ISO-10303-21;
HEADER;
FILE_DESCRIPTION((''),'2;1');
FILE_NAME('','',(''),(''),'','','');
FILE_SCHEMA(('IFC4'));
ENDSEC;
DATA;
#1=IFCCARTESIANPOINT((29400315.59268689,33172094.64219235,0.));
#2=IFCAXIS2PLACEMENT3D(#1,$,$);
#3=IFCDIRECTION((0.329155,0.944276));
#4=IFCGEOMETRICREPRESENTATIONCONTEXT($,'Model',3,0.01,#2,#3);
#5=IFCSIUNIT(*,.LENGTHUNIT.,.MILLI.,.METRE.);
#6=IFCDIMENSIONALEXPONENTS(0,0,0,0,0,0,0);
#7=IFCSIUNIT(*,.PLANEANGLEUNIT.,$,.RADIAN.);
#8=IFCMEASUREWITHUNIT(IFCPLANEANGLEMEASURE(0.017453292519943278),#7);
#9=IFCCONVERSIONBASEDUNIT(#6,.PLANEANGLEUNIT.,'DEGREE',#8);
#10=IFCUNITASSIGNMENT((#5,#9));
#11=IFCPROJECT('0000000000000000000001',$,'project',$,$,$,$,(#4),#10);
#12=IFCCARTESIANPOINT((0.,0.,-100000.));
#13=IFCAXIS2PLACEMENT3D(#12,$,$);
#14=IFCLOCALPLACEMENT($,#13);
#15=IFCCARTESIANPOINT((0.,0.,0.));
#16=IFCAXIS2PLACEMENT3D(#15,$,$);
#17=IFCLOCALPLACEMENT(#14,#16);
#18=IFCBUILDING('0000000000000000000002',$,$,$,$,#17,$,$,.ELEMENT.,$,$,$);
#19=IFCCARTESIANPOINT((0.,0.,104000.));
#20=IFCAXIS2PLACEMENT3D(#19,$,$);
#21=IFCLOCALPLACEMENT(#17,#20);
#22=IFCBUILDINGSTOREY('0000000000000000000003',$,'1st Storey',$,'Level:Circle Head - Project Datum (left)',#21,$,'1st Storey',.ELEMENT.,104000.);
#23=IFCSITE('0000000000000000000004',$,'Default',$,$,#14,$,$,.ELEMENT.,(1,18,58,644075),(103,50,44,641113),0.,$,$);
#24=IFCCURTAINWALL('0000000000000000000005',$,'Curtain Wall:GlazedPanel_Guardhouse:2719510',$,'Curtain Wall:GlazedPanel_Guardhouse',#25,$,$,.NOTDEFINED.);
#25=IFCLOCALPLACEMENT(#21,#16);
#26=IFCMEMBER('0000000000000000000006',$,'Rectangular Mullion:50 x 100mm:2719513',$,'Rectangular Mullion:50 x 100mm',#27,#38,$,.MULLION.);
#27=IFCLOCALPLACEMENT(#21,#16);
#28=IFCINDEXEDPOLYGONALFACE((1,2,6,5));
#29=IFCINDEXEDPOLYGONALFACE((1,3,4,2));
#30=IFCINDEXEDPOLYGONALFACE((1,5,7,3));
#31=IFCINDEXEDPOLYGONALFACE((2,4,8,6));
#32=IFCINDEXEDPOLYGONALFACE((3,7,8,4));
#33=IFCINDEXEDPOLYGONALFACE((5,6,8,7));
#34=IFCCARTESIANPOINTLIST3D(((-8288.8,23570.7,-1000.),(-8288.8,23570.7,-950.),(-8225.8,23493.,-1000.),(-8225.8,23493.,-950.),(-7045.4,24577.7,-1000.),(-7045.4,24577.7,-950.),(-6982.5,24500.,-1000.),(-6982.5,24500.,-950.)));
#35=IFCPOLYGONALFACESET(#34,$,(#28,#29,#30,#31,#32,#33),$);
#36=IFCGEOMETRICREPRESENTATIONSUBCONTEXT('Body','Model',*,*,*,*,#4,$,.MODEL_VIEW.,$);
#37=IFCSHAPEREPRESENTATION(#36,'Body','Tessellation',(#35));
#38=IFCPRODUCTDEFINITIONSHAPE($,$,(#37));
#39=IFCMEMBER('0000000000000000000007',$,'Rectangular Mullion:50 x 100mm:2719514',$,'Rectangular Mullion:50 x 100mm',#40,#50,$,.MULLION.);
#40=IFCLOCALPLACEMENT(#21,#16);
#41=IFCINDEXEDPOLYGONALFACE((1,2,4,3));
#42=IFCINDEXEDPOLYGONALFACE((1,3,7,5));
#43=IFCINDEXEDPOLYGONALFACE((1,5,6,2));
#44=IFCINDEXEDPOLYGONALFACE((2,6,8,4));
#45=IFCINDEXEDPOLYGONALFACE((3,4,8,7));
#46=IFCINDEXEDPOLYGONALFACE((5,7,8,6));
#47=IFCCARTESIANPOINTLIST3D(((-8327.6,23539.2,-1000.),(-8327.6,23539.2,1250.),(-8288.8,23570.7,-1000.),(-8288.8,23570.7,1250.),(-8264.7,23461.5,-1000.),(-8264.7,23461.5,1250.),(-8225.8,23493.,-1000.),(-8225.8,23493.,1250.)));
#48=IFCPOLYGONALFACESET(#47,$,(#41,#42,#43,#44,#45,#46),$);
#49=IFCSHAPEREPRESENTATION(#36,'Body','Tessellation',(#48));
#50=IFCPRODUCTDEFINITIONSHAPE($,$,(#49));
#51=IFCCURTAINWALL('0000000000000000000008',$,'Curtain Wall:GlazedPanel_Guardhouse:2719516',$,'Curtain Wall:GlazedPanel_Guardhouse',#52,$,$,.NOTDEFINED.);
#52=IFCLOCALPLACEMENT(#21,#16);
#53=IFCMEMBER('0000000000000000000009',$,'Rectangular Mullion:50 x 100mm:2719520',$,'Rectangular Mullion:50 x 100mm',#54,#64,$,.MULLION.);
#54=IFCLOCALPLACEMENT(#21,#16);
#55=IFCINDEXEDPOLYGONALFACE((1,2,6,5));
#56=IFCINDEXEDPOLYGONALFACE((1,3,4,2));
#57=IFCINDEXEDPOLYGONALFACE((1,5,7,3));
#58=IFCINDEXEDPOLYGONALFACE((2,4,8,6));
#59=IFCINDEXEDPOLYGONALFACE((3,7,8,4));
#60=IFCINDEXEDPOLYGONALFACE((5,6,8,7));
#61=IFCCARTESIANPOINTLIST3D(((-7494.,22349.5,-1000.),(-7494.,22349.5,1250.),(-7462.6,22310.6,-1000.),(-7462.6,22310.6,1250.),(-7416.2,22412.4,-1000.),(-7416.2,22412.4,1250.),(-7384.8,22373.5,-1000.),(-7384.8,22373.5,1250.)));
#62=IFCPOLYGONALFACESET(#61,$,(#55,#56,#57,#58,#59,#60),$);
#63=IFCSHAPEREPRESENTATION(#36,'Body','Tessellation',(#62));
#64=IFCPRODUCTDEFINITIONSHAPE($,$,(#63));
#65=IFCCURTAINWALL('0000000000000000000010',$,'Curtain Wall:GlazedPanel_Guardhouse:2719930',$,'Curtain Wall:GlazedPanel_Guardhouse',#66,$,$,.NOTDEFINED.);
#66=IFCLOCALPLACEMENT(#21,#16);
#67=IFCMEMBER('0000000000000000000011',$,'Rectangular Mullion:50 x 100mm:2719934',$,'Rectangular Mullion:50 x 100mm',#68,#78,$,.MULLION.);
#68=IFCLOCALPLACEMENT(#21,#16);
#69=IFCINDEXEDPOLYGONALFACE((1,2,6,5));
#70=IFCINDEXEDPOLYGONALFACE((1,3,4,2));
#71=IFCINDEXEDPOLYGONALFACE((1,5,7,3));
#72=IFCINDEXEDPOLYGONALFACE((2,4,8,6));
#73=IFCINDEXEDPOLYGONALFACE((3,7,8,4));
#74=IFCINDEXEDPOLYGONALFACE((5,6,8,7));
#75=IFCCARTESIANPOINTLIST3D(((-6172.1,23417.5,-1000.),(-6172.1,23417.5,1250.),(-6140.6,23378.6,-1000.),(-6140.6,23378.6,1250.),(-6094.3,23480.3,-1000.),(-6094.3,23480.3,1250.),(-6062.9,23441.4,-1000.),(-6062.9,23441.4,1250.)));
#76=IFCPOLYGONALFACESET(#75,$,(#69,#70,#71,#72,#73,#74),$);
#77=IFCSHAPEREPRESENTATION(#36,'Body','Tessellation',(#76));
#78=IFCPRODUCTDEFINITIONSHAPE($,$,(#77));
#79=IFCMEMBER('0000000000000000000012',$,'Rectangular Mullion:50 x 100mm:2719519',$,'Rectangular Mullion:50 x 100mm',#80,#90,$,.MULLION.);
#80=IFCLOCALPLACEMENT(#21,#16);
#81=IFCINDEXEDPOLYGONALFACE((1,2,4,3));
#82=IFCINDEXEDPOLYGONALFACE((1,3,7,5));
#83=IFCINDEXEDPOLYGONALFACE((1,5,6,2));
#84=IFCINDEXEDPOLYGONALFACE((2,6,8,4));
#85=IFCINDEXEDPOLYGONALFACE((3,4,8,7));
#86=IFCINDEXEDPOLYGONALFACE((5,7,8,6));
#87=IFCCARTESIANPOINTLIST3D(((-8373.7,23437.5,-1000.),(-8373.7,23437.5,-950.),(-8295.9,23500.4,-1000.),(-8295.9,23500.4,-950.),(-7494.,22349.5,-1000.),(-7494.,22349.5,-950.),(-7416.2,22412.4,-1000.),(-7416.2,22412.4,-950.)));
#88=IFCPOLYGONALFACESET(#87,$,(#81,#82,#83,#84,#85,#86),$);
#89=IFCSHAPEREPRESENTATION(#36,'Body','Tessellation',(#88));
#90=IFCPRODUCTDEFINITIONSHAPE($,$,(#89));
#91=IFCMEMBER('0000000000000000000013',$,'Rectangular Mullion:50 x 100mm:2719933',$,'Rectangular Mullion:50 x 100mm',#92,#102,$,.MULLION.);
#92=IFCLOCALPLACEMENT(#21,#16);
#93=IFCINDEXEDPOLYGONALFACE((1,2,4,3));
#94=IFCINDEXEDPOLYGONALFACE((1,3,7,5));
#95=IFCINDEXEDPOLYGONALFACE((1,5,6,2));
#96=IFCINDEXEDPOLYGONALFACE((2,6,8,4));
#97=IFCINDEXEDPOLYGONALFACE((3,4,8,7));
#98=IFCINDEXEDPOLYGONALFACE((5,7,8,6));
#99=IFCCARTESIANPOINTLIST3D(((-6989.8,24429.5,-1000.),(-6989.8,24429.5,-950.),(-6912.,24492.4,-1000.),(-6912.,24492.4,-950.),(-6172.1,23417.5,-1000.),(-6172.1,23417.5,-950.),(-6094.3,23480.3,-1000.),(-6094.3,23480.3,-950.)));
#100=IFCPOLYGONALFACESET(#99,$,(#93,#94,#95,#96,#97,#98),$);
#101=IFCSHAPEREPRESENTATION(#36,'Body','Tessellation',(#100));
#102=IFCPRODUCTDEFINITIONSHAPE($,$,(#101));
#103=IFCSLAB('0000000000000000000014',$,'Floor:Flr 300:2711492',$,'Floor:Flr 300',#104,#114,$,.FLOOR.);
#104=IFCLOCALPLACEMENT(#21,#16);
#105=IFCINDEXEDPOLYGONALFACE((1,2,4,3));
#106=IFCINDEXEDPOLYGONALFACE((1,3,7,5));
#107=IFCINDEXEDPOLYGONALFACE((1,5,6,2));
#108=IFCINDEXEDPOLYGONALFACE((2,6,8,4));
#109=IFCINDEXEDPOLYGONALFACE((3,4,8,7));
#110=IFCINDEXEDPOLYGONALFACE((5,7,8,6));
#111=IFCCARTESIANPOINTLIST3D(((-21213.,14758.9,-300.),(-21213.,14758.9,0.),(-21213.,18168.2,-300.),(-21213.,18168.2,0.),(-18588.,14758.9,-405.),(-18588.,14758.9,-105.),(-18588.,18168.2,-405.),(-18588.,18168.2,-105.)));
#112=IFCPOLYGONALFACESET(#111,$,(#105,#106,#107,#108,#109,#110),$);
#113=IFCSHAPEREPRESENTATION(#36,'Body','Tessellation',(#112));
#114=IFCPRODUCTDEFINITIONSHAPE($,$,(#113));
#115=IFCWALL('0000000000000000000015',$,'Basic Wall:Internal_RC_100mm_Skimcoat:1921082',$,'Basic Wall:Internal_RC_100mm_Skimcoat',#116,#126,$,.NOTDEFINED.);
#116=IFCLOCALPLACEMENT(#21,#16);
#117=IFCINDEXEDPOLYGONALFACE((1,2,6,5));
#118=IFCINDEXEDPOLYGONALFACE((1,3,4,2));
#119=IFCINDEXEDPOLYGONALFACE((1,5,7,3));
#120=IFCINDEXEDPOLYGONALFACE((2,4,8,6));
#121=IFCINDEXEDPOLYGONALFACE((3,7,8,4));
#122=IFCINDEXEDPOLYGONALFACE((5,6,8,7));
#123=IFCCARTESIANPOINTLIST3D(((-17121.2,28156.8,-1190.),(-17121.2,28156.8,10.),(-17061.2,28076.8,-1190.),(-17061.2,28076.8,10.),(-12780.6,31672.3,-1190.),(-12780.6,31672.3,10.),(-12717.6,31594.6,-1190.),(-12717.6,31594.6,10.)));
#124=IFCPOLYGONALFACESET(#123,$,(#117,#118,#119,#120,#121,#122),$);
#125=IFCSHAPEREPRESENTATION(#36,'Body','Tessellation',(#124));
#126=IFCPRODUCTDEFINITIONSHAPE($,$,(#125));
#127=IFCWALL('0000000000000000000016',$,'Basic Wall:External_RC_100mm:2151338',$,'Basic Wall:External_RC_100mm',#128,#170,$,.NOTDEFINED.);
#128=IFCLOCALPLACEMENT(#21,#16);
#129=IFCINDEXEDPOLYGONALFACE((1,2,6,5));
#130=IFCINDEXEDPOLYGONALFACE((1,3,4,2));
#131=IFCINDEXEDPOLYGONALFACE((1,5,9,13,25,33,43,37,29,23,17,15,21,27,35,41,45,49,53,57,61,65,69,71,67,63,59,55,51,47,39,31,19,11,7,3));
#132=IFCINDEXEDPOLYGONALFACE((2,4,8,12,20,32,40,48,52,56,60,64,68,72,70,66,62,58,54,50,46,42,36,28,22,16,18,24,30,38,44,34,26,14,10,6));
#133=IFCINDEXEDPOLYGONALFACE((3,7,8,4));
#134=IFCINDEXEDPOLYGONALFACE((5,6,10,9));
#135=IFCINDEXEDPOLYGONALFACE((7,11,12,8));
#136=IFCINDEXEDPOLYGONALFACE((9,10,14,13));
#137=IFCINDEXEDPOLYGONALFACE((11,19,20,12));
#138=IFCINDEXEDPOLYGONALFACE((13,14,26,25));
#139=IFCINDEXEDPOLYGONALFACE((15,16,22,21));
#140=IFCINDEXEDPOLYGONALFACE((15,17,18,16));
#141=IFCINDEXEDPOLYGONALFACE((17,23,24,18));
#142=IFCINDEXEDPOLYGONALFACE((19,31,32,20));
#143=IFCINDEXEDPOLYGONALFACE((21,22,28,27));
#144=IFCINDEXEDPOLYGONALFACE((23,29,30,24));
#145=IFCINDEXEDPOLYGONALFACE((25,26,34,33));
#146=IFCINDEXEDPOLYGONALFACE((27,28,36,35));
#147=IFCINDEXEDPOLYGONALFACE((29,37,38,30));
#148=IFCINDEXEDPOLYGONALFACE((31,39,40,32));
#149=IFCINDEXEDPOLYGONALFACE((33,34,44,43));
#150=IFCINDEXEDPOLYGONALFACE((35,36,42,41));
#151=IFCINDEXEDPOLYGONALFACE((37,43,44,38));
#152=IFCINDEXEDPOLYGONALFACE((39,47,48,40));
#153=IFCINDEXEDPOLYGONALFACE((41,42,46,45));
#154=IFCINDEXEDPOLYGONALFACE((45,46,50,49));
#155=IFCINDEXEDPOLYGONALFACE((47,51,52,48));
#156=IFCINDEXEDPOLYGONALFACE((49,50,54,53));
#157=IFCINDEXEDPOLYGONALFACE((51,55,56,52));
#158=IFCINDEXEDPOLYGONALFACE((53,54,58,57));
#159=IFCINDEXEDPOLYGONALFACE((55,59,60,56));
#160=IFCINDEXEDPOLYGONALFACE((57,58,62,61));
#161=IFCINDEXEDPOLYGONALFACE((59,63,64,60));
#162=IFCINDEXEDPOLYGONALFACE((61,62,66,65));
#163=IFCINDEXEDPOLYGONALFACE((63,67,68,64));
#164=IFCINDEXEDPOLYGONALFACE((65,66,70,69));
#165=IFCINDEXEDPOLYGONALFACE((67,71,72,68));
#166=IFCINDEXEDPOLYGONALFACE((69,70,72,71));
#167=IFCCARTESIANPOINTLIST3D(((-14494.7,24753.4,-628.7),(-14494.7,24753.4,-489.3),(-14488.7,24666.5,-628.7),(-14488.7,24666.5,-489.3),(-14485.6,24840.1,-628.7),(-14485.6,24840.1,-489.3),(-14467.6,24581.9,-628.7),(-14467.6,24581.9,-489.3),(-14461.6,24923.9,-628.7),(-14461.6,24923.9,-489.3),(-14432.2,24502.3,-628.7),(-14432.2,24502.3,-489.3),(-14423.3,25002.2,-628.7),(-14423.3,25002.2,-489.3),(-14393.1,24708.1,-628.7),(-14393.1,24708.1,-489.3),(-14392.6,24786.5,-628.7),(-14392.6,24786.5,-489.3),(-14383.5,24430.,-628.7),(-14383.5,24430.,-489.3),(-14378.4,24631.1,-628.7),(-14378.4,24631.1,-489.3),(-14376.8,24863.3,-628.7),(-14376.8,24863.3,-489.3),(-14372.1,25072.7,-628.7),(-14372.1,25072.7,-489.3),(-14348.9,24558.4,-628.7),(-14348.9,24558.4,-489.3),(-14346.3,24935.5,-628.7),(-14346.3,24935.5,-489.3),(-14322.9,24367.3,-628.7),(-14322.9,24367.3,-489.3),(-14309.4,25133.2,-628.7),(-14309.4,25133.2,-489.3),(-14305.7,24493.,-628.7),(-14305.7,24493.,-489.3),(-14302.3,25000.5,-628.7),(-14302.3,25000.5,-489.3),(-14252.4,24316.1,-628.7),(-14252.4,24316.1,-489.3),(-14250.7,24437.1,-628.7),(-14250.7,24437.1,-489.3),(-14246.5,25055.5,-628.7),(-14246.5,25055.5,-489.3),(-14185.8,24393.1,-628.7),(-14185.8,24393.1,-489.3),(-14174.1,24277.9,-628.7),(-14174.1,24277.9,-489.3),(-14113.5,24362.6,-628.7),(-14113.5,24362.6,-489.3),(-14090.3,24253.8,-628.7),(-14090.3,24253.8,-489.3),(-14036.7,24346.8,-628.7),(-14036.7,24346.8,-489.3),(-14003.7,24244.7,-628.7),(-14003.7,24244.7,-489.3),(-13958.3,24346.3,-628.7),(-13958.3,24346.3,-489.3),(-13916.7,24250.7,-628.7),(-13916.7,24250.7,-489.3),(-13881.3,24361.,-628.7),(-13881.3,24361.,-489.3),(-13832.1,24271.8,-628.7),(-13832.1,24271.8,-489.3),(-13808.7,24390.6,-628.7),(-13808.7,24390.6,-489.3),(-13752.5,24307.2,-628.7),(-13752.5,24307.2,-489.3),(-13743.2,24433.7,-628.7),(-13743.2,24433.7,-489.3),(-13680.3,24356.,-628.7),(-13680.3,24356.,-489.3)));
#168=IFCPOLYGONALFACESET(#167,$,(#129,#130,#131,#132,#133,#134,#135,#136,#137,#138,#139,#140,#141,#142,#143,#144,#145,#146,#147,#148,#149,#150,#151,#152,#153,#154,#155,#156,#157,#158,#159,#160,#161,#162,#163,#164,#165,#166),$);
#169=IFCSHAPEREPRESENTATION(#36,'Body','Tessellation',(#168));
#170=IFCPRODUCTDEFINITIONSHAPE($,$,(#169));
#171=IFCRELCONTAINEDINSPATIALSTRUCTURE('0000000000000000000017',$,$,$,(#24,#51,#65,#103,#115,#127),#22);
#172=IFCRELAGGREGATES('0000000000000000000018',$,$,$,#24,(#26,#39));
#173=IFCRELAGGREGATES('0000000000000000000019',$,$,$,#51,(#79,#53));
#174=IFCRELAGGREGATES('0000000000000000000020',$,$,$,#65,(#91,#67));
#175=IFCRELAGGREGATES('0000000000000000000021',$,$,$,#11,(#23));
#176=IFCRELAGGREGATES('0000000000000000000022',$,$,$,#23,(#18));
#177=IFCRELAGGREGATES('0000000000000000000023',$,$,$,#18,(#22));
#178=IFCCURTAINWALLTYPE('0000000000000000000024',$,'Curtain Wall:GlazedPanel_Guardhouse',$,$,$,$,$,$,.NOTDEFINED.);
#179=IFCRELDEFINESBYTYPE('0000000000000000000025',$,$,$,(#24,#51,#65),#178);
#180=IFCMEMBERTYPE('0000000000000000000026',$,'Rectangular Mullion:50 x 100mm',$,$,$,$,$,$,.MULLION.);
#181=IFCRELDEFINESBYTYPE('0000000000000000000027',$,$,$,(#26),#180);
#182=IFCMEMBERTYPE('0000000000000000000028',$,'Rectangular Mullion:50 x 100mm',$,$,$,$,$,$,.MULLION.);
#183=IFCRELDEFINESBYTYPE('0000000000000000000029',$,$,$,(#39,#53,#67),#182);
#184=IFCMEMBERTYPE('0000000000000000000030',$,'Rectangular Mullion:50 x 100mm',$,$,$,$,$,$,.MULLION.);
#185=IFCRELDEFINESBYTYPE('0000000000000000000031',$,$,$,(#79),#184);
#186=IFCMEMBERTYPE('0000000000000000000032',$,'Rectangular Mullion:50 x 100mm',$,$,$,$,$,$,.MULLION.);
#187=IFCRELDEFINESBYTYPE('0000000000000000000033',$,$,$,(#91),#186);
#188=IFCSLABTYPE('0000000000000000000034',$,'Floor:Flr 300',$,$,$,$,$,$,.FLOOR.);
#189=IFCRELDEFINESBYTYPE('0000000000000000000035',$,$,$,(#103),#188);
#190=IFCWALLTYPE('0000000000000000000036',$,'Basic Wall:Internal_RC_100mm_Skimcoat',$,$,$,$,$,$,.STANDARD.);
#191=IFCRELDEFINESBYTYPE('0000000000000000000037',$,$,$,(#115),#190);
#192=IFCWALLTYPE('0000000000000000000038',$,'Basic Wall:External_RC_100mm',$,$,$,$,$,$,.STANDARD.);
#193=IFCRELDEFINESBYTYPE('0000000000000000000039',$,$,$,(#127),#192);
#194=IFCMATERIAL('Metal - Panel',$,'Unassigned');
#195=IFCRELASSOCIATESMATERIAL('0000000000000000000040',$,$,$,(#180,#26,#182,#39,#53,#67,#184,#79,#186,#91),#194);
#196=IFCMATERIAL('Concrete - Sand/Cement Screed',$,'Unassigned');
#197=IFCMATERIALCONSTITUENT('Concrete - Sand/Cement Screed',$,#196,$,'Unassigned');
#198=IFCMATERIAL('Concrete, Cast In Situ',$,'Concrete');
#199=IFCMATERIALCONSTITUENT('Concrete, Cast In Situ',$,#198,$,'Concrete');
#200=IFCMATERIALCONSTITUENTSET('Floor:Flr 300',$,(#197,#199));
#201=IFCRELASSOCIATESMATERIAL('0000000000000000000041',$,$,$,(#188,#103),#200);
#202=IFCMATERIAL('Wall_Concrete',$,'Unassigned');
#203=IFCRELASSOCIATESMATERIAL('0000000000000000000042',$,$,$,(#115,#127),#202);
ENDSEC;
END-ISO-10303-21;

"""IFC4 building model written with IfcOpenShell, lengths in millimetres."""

from ifc_helpers import new_model, entity, si_unit, converted_unit, direction, frame, frame_2d, origin, place, context, subcontext, project, spatial, line, arc, indexed_curve, rectangle, outline, extrude, source, transform, mapped, material, constituent, constituent_set, type_object, type_shapes, element, aggregate, save


model = new_model("IFC4")

# Units and contexts
model_context = context("Model", 3, precision=0.01, world=frame((29400315.59268689, 33172094.64219235, 0.0)), true_north=direction((0.329155, 0.944276)))
body_context = subcontext(model_context, "Body", "Model", "MODEL_VIEW")
ifc_project = project(units=[si_unit("LENGTHUNIT", "METRE", prefix="MILLI"), converted_unit("PLANEANGLEUNIT", "DEGREE", entity("IfcPlaneAngleMeasure", 0.017453292519943278), si_unit("PLANEANGLEUNIT", "RADIAN"), dimensions=[0, 0, 0, 0, 0, 0, 0])], contexts=[model_context])

# Site, building, storey
site_placement = place(None, frame((0.0, 0.0, -100000.0)))
site = spatial("IfcSite", under=ifc_project, at=site_placement, Name="Default", CompositionType="ELEMENT", RefLatitude=(1, 18, 58, 644075), RefLongitude=(103, 50, 44, 641113), RefElevation=0.0)
building_placement = place(site_placement, origin())
building = spatial("IfcBuilding", under=site, at=building_placement, CompositionType="ELEMENT")
storey_placement = place(building_placement, frame((0.0, 0.0, 104000.0)))
storey = spatial("IfcBuildingStorey", under=building, at=storey_placement, Name="1st Storey", ObjectType="Level:Circle Head - Project Datum (left)", LongName="1st Storey", CompositionType="ELEMENT", Elevation=104000.0)

# Curtain wall, members
curtain_wall_type = type_object("IfcCurtainWallType", Name="Curtain Wall:GlazedPanel_Guardhouse", PredefinedType="NOTDEFINED")
curtain_wall_1_placement = place(storey_placement, frame((0.0, 0.0, -104000.0)))
curtain_wall_1 = element("IfcCurtainWall", 1, at=curtain_wall_1_placement, inside=storey, type_object=curtain_wall_type, Name="Curtain Wall:GlazedPanel_Guardhouse:2719510", ObjectType="Curtain Wall:GlazedPanel_Guardhouse", PredefinedType="NOTDEFINED")
ifc_material_1 = material(Name="Metal - Panel", Category="Unassigned")
member_type_1 = type_object("IfcMemberType", Name="Rectangular Mullion:50 x 100mm", PredefinedType="MULLION", material=ifc_material_1)
shared_shape_1 = source(origin(), body_context, "Body", "SweptSolid", [
    extrude(outline(indexed_curve([(-25.0, -50.0), (25.0, -50.0), (25.0, 50.0), (-25.0, 50.0), (-25.0, -50.0)], self_intersect=False)), frame((-25.0, 0.0, -1600.0), z_axis=(0.0, 0.0, 1.0), x_axis=(-1.0, 0.0, 0.0)), (0.0, 0.0, 1.0), 1600.0),
])
type_shapes(member_type_1, [shared_shape_1])
member_1_placement = place(curtain_wall_1_placement, frame((-7013.9, 24538.8, 103000.0), z_axis=(0.777102, 0.629375, 0.0), x_axis=(0.0, 0.0, -1.0)))
member_1 = element("IfcMember", 2, at=member_1_placement, type_object=member_type_1, material=ifc_material_1, Name="Rectangular Mullion:50 x 100mm:2719513", ObjectType="Rectangular Mullion:50 x 100mm", PredefinedType="MULLION", context=body_context, shape_type="MappedRepresentation", body=[
    mapped(shared_shape_1, transform((0.0, 0.0, 0.0), scale=1.0)),
])
member_type_2 = type_object("IfcMemberType", Name="Rectangular Mullion:50 x 100mm", PredefinedType="MULLION", material=ifc_material_1)
shared_shape_2 = source(origin(), body_context, "Body", "SweptSolid", [
    extrude(outline(indexed_curve([(-25.0, -50.0), (25.0, -50.0), (25.0, 50.0), (-25.0, 50.0), (-25.0, -50.0)], self_intersect=False)), frame((-25.0, 0.0, -2250.0), z_axis=(0.0, 0.0, 1.0), x_axis=(-1.0, 0.0, 0.0)), (0.0, 0.0, 1.0), 2250.0),
])
type_shapes(member_type_2, [shared_shape_2])
member_2_placement = place(curtain_wall_1_placement, frame((-8296.2, 23500.3, 103000.0), z_axis=(0.0, 0.0, -1.0), x_axis=(-0.777102, -0.629375, 0.0)))
member_2 = element("IfcMember", 3, at=member_2_placement, type_object=member_type_2, material=ifc_material_1, Name="Rectangular Mullion:50 x 100mm:2719514", ObjectType="Rectangular Mullion:50 x 100mm", PredefinedType="MULLION", context=body_context, shape_type="MappedRepresentation", body=[
    mapped(shared_shape_2, transform((0.0, 0.0, 0.0), scale=1.0)),
])

# Curtain walls, members
curtain_wall_2_placement = place(storey_placement, frame((0.0, 0.0, -104000.0)))
curtain_wall_2 = element("IfcCurtainWall", 4, at=curtain_wall_2_placement, inside=storey, type_object=curtain_wall_type, Name="Curtain Wall:GlazedPanel_Guardhouse:2719516", ObjectType="Curtain Wall:GlazedPanel_Guardhouse", PredefinedType="NOTDEFINED")
member_3_placement = place(curtain_wall_2_placement, frame((-7423.7, 22342.1, 103000.0), z_axis=(0.0, 0.0, -1.0), x_axis=(0.628737, -0.777618, 0.0)))
member_3 = element("IfcMember", 5, at=member_3_placement, type_object=member_type_2, material=ifc_material_1, Name="Rectangular Mullion:50 x 100mm:2719520", ObjectType="Rectangular Mullion:50 x 100mm", PredefinedType="MULLION", context=body_context, shape_type="MappedRepresentation", body=[
    mapped(shared_shape_2, transform((0.0, 0.0, 0.0), scale=1.0)),
])
curtain_wall_3_placement = place(storey_placement, frame((0.0, 0.0, -104000.0)))
curtain_wall_3 = element("IfcCurtainWall", 6, at=curtain_wall_3_placement, inside=storey, type_object=curtain_wall_type, Name="Curtain Wall:GlazedPanel_Guardhouse:2719930", ObjectType="Curtain Wall:GlazedPanel_Guardhouse", PredefinedType="NOTDEFINED")
member_4_placement = place(curtain_wall_3_placement, frame((-6101.8, 23410.0, 103000.0), z_axis=(0.0, 0.0, -1.0), x_axis=(0.628476, -0.777829, 0.0)))
member_4 = element("IfcMember", 7, at=member_4_placement, type_object=member_type_2, material=ifc_material_1, Name="Rectangular Mullion:50 x 100mm:2719934", ObjectType="Rectangular Mullion:50 x 100mm", PredefinedType="MULLION", context=body_context, shape_type="MappedRepresentation", body=[
    mapped(shared_shape_2, transform((0.0, 0.0, 0.0), scale=1.0)),
])

# Members
member_type_3 = type_object("IfcMemberType", Name="Rectangular Mullion:50 x 100mm", PredefinedType="MULLION", material=ifc_material_1)
shared_shape_3 = source(origin(), body_context, "Body", "SweptSolid", [
    extrude(outline(indexed_curve([(-25.0, -50.0), (25.0, -50.0), (25.0, 50.0), (-25.0, 50.0), (-25.0, -50.0)], self_intersect=False)), frame((-25.0, 0.0, -1399.2), z_axis=(0.0, 0.0, 1.0), x_axis=(-1.0, 0.0, 0.0)), (0.0, 0.0, 1.0), 1399.2),
])
type_shapes(member_type_3, [shared_shape_3])
member_5_placement = place(curtain_wall_2_placement, frame((-8334.8, 23469.0, 103000.0), z_axis=(-0.628737, 0.777618, 0.0), x_axis=(0.0, 0.0, -1.0)))
member_5 = element("IfcMember", 8, at=member_5_placement, type_object=member_type_3, material=ifc_material_1, Name="Rectangular Mullion:50 x 100mm:2719519", ObjectType="Rectangular Mullion:50 x 100mm", PredefinedType="MULLION", context=body_context, shape_type="MappedRepresentation", body=[
    mapped(shared_shape_3, transform((0.0, 0.0, 0.0), scale=1.0)),
])
member_type_4 = type_object("IfcMemberType", Name="Rectangular Mullion:50 x 100mm", PredefinedType="MULLION", material=ifc_material_1)
shared_shape_4 = source(origin(), body_context, "Body", "SweptSolid", [
    extrude(outline(indexed_curve([(-25.0, -50.0), (25.0, -50.0), (25.0, 50.0), (-25.0, 50.0), (-25.0, -50.0)], self_intersect=False)), frame((-25.0, 0.0, -1301.2), z_axis=(0.0, 0.0, 1.0), x_axis=(-1.0, 0.0, 0.0)), (0.0, 0.0, 1.0), 1301.2),
])
type_shapes(member_type_4, [shared_shape_4])
member_6_placement = place(curtain_wall_3_placement, frame((-6950.9, 24461.0, 103000.0), z_axis=(-0.628476, 0.777829, 0.0), x_axis=(0.0, 0.0, -1.0)))
member_6 = element("IfcMember", 9, at=member_6_placement, type_object=member_type_4, material=ifc_material_1, Name="Rectangular Mullion:50 x 100mm:2719933", ObjectType="Rectangular Mullion:50 x 100mm", PredefinedType="MULLION", context=body_context, shape_type="MappedRepresentation", body=[
    mapped(shared_shape_4, transform((0.0, 0.0, 0.0), scale=1.0)),
])

# Slab
ifc_material_2 = material(Name="Concrete - Sand/Cement Screed", Category="Unassigned")
ifc_constituent_1 = constituent(ifc_material_2, Name="Concrete - Sand/Cement Screed", Category="Unassigned")
ifc_material_3 = material(Name="Concrete, Cast In Situ", Category="Concrete")
ifc_constituent_2 = constituent(ifc_material_3, Name="Concrete, Cast In Situ", Category="Concrete")
ifc_constituent_set = constituent_set(constituents=[ifc_constituent_1, ifc_constituent_2], Name="Floor:Flr 300")
slab_type = type_object("IfcSlabType", Name="Floor:Flr 300", PredefinedType="FLOOR", material=ifc_constituent_set)
for number, where, name in (
    (10, (-21213.0, 14758.9, -405.0), "Floor:Flr 300:2711492"),
):
    element("IfcSlab", number, at=place(storey_placement, frame(where)), inside=storey, type_object=slab_type, material=ifc_constituent_set, Name=name, ObjectType="Floor:Flr 300", PredefinedType="FLOOR", context=body_context, shape_type="SweptSolid", body=[
        extrude(rectangle(XDim=2627.1, YDim=3409.3, at=frame_2d((0.0, 0.0), x_axis=(-1.0, 0.0))), frame((1312.5, 1704.6, 352.5), z_axis=(0.039968, 0.0, 0.999201), x_axis=(0.999201, 0.0, -0.039968)), (0.039968, 0.0, -0.999201), 300.0),
    ])

aggregate(curtain_wall_1, [member_1, member_2])
aggregate(curtain_wall_2, [member_5, member_3])
aggregate(curtain_wall_3, [member_6, member_4])

# Walls
ifc_material_4 = material(Name="Wall_Concrete", Category="Unassigned")
wall_type_1 = type_object("IfcWallType", Name="Basic Wall:Internal_RC_100mm_Skimcoat", PredefinedType="STANDARD")
wall_1_placement = place(storey_placement, frame((-17092.6, 28115.6, -1190.0), z_axis=(0.0, 0.0, 1.0), x_axis=(0.777102, 0.629375, 0.0)))
element("IfcWall", 11, at=wall_1_placement, inside=storey, type_object=wall_type_1, material=ifc_material_4, Name="Basic Wall:Internal_RC_100mm_Skimcoat:1921082", ObjectType="Basic Wall:Internal_RC_100mm_Skimcoat", PredefinedType="NOTDEFINED", context=body_context, shape_type="SweptSolid", body=[
    extrude(outline(indexed_curve([(5589.4, -50.0), (5589.4, 50.0), (3.8, 50.0), (0.0, -50.0), (5589.4, -50.0)], self_intersect=False)), origin(), (0.0, 0.0, 1.0), 1200.0),
])
wall_type_2 = type_object("IfcWallType", Name="Basic Wall:External_RC_100mm", PredefinedType="STANDARD")
wall_2_placement = place(storey_placement, frame((-14277.9, 25094.4, -628.7)))
element("IfcWall", 12, at=wall_2_placement, inside=storey, type_object=wall_type_2, material=ifc_material_4, Name="Basic Wall:External_RC_100mm:2151338", ObjectType="Basic Wall:External_RC_100mm", PredefinedType="NOTDEFINED", context=body_context, shape_type="SweptSolid", body=[
    extrude(outline(indexed_curve([(534.8, -660.7), (-27.8, -601.4), (31.5, -38.9), (-31.5, 38.9), (-105.5, -664.3), (597.7, -738.4)], segments=[arc(1, 2, 3), line(3, 4), arc(4, 5, 6), line(6, 1)], self_intersect=False)), origin(), (0.0, 0.0, 1.0), 139.4),
])

save(model, "model.ifc")
